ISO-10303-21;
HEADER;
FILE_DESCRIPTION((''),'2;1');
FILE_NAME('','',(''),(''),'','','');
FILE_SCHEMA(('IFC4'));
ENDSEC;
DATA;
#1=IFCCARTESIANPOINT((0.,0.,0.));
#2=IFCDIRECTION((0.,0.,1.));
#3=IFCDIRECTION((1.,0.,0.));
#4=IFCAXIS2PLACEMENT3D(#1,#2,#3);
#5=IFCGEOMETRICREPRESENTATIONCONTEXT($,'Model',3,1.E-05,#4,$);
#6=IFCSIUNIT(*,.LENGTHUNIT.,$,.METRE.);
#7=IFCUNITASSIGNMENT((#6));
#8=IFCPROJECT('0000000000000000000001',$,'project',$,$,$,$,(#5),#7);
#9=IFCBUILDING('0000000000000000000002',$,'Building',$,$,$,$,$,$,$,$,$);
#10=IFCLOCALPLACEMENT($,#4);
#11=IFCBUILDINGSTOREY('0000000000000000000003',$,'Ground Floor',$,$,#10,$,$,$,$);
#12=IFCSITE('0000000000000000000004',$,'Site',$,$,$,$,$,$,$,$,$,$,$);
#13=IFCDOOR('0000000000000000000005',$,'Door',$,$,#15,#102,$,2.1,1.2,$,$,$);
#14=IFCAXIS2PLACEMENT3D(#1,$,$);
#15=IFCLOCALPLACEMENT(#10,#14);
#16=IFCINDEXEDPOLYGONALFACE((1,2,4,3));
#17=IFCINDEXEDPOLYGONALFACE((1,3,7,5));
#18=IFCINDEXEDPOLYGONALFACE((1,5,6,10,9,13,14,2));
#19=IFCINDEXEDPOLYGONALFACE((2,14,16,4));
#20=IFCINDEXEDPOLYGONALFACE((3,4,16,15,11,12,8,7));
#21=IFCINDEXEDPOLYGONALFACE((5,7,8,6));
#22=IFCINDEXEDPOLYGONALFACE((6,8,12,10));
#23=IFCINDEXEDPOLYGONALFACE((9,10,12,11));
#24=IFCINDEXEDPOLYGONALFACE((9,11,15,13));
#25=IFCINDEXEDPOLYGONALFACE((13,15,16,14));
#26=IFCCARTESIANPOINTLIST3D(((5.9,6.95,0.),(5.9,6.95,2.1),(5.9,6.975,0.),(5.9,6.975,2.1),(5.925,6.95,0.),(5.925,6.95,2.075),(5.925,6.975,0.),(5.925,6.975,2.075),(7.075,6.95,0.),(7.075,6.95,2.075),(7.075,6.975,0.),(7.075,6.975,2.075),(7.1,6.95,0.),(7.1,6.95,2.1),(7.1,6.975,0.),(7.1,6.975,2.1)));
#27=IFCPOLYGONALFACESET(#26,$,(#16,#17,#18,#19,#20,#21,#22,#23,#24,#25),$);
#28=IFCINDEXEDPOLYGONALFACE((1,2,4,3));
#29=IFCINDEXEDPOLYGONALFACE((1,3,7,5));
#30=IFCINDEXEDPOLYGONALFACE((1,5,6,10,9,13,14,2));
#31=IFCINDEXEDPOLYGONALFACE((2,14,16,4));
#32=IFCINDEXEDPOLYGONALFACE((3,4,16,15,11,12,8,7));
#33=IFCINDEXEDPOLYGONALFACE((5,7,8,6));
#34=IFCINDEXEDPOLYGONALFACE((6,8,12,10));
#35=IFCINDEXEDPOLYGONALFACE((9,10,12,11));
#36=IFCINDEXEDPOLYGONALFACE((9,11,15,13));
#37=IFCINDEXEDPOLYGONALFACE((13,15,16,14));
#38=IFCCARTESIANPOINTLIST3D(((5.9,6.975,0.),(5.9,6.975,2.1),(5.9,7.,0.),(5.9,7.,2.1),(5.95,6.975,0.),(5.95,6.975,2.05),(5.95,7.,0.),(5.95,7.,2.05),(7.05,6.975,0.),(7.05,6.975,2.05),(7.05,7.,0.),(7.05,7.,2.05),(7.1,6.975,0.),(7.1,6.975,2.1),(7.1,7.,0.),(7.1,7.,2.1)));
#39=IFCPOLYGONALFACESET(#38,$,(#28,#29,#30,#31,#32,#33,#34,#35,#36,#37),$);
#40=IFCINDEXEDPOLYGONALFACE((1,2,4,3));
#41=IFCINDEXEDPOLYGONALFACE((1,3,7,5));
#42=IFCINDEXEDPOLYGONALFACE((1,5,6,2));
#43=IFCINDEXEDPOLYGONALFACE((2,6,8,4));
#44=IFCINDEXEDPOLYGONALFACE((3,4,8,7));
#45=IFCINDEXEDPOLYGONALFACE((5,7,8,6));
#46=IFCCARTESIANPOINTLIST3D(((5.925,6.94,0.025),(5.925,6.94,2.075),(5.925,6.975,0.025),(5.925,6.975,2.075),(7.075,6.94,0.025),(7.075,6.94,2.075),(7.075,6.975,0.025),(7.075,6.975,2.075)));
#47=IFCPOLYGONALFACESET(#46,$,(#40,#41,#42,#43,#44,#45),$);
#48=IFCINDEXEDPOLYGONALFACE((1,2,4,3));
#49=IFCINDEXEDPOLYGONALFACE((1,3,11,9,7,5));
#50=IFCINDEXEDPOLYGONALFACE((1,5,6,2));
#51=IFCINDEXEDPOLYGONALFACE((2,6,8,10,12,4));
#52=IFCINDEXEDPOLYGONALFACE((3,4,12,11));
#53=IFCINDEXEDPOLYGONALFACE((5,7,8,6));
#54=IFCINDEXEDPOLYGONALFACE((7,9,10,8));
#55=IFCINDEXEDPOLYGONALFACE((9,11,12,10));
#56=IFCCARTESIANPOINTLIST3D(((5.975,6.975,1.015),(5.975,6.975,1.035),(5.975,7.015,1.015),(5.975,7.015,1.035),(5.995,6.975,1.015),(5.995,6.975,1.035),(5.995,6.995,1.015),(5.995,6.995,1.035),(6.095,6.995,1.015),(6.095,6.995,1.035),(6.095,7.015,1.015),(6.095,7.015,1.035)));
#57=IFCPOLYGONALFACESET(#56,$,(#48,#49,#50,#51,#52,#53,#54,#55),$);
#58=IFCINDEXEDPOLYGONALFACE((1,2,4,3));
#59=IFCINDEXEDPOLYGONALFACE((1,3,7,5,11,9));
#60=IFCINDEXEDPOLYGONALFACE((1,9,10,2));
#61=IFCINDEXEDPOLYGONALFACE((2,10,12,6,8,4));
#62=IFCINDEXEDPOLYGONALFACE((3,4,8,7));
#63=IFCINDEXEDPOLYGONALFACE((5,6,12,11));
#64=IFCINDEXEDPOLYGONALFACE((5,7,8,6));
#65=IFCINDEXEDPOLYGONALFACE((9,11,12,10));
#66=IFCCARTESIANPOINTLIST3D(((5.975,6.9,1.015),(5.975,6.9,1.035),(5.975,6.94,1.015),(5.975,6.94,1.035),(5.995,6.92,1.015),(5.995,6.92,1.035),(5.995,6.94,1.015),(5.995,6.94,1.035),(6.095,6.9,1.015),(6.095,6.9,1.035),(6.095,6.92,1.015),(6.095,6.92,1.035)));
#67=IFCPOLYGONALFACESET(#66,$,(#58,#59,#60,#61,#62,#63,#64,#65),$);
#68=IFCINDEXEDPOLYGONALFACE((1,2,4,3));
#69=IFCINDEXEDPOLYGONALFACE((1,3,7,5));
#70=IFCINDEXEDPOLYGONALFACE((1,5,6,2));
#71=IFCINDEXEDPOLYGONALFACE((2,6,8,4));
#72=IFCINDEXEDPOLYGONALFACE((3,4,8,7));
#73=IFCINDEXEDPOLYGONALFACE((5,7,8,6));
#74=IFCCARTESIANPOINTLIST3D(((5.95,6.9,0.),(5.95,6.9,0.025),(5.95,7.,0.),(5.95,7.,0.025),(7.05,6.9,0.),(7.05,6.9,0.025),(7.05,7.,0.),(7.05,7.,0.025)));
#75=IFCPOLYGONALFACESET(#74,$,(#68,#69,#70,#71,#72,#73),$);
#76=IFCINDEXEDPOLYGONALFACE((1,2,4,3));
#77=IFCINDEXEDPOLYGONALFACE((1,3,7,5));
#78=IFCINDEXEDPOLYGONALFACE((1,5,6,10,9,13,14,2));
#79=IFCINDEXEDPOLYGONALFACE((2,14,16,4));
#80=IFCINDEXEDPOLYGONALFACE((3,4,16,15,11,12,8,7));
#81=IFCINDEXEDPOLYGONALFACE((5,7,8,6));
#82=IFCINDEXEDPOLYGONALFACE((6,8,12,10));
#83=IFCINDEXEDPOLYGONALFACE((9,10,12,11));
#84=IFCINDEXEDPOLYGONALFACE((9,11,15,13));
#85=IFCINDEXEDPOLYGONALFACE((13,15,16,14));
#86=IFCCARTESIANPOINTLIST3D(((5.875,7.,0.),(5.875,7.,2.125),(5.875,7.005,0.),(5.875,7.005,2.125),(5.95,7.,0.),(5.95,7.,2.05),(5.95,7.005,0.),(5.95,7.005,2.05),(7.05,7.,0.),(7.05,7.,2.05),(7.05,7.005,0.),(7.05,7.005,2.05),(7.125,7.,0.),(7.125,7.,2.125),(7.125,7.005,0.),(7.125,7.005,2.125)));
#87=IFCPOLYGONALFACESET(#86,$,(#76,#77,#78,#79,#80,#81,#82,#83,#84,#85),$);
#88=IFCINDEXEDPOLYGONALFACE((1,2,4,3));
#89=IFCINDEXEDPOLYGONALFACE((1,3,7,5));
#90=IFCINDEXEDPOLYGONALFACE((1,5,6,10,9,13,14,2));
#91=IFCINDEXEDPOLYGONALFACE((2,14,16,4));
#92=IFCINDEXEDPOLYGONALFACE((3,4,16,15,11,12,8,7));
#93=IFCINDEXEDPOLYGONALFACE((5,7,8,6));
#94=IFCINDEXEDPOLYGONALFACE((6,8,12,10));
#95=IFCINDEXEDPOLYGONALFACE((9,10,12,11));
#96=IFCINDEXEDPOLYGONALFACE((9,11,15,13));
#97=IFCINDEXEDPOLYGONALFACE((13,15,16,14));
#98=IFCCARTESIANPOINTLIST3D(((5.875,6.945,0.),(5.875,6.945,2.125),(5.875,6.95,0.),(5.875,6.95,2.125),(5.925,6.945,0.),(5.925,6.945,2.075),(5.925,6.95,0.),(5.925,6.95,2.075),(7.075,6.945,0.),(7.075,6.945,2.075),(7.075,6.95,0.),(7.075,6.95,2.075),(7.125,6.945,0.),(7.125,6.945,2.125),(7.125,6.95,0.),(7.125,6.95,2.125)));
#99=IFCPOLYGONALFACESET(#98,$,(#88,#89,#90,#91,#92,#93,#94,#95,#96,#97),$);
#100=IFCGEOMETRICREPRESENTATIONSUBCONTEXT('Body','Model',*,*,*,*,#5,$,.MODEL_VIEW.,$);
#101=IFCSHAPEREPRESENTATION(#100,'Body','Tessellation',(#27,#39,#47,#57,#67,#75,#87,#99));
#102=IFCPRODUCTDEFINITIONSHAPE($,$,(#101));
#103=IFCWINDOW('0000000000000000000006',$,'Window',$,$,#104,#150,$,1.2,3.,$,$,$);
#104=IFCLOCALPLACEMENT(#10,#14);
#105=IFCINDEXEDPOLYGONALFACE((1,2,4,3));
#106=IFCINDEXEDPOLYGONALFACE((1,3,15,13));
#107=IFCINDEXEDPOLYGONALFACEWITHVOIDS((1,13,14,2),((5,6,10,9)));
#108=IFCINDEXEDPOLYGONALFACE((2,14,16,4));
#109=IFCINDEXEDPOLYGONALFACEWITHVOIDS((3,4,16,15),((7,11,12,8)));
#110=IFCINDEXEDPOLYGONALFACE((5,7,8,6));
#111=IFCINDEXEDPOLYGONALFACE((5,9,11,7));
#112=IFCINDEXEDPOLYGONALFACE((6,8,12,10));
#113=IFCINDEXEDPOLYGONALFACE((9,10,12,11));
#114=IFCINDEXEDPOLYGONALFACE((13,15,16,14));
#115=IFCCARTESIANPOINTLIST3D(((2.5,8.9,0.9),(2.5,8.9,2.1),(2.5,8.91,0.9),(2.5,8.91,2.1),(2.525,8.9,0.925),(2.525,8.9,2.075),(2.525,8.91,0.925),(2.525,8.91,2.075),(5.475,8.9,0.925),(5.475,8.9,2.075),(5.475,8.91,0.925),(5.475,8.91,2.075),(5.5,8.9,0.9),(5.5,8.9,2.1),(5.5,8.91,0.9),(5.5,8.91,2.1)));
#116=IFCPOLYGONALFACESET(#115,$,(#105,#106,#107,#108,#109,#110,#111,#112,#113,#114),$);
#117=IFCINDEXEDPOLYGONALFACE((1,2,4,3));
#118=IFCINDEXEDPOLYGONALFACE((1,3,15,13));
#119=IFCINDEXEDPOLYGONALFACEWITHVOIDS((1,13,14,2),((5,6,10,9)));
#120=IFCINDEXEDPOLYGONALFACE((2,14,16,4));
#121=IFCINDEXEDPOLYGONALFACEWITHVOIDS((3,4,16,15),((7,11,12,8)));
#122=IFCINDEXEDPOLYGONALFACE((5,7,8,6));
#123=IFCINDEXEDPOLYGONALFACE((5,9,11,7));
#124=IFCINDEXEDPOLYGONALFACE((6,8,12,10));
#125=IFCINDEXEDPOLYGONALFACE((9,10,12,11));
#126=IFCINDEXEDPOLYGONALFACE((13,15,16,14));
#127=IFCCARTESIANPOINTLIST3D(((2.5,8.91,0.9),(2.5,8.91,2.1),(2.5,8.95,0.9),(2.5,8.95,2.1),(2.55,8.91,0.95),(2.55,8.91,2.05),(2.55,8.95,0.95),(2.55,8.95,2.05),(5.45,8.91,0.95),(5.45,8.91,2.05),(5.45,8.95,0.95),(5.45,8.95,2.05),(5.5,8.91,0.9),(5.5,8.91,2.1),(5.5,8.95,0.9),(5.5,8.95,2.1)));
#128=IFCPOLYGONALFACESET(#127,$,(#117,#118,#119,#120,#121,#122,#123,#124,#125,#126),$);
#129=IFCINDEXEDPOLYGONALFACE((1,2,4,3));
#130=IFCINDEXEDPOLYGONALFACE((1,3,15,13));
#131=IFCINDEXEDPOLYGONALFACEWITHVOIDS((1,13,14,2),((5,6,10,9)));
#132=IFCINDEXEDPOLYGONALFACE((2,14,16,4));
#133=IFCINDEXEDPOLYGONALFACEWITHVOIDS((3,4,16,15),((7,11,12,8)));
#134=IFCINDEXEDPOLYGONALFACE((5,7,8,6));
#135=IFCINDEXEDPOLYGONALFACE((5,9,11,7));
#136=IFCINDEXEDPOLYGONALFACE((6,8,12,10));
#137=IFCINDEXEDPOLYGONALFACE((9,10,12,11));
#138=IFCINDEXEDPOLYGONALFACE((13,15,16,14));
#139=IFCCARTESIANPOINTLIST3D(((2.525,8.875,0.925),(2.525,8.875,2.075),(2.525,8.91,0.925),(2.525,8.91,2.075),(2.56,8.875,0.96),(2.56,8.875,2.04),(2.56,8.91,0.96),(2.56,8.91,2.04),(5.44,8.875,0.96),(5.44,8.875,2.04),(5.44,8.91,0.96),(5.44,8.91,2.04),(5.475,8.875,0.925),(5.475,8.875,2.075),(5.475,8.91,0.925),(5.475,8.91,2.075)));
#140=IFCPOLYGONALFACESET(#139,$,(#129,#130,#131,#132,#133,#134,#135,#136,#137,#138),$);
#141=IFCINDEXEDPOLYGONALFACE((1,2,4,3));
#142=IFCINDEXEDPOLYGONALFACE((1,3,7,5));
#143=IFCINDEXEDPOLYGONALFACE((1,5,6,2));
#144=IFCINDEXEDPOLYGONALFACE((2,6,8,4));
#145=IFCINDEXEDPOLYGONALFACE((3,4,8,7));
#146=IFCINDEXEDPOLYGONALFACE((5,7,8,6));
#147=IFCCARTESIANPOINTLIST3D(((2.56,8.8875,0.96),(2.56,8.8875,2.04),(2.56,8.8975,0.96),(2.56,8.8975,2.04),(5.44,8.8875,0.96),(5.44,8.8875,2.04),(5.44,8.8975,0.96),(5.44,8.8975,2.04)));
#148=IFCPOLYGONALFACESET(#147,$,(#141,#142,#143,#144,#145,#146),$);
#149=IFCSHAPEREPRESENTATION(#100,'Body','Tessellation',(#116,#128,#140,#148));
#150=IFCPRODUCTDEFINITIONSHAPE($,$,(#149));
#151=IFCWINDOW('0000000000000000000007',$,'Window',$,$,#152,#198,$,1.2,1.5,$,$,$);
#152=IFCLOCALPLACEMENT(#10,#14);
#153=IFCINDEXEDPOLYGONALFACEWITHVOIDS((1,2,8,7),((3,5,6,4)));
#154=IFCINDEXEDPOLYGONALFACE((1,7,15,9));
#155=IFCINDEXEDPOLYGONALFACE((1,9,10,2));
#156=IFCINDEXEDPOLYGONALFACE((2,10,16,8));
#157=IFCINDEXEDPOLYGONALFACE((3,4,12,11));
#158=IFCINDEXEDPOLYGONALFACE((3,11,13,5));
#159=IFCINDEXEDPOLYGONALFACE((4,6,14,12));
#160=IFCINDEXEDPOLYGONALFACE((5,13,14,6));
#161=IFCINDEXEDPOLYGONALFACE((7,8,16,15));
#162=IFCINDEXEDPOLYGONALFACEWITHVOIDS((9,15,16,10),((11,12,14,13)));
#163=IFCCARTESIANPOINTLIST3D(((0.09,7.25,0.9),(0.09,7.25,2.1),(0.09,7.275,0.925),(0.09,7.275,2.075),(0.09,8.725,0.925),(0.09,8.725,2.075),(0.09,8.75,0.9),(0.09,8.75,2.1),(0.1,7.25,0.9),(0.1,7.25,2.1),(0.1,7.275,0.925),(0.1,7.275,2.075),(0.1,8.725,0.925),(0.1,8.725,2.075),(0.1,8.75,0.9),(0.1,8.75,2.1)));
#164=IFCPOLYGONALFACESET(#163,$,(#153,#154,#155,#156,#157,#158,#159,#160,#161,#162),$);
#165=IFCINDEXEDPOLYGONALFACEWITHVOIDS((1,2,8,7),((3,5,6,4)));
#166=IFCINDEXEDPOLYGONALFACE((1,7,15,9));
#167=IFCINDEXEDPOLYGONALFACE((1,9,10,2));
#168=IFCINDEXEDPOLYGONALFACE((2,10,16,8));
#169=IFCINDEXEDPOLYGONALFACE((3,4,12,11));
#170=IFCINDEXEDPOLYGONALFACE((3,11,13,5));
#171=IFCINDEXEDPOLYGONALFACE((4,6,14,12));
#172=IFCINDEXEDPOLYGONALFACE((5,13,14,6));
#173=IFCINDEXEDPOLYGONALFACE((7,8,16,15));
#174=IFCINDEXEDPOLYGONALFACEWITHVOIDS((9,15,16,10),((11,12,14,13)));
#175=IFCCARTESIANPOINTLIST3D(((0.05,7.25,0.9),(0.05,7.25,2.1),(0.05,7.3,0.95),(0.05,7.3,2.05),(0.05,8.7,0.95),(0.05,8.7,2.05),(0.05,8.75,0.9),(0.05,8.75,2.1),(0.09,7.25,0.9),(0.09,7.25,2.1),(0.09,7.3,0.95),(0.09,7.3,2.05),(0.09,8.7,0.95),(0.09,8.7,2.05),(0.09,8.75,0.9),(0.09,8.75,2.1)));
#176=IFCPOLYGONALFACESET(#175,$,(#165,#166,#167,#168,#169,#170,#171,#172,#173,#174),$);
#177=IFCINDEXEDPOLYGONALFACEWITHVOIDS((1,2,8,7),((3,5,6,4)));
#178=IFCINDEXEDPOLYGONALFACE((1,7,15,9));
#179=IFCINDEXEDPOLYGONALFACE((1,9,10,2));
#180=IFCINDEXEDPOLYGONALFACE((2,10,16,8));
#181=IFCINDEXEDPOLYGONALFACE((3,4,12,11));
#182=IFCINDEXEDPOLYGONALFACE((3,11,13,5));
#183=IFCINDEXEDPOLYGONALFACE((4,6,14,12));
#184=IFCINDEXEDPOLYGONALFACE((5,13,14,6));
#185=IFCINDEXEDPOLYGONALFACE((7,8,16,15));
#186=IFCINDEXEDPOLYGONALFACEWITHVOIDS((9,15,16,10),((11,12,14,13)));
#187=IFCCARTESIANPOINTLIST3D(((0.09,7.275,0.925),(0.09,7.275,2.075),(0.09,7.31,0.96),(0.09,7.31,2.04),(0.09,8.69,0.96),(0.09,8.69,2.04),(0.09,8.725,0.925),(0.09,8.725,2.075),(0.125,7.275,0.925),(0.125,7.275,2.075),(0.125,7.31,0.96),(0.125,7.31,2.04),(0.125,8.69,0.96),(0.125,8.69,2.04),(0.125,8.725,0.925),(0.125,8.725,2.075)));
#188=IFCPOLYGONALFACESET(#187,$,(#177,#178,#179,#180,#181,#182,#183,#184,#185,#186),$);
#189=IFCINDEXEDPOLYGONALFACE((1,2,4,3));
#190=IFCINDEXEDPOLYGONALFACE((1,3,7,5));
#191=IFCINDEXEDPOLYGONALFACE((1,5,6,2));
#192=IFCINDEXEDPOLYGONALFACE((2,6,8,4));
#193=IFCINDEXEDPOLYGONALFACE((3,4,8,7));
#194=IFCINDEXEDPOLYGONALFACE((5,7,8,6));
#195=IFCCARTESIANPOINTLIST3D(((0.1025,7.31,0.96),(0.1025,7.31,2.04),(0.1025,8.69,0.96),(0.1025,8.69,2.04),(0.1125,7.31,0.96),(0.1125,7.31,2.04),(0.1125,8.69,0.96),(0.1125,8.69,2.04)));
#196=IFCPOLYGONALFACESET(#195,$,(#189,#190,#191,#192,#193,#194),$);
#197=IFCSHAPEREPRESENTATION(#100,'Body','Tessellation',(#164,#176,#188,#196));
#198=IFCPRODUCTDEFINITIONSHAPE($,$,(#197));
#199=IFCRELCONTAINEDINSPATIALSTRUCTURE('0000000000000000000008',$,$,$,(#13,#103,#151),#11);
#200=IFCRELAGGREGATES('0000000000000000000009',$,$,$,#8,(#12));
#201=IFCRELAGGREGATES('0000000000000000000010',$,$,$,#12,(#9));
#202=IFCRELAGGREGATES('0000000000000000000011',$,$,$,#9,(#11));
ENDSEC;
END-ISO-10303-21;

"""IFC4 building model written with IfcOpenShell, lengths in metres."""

from ifc_helpers import new_model, si_unit, frame, origin_with_axes, place, context, subcontext, project, spatial, line, indexed_curve, outline, extrude, element, save


model = new_model("IFC4")

# Units and contexts
model_context = context("Model", 3, precision=1e-05, world=origin_with_axes())
body_context = subcontext(model_context, "Body", "Model", "MODEL_VIEW")
ifc_project = project(units=[si_unit("LENGTHUNIT", "METRE")], contexts=[model_context])

# Site, building, storey
site = spatial("IfcSite", under=ifc_project, Name="Site")
building = spatial("IfcBuilding", under=site, Name="Building")
storey_placement = place(None, origin_with_axes())
storey = spatial("IfcBuildingStorey", under=building, at=storey_placement, Name="Ground Floor")

# Door
door_1_placement = place(storey_placement, frame((7.1, 7.0, 0.0), z_axis=(0.0, 0.0, 1.0), x_axis=(-1.0, 0.0, 0.0)))
element("IfcDoor", 1, at=door_1_placement, inside=storey, Name="Door", OverallHeight=2.1, OverallWidth=1.2, context=body_context, shape_type="SweptSolid", body=[
    extrude(outline(indexed_curve([(0.0, 0.0), (0.0, 2.1), (1.2, 2.1), (1.2, 0.0), (1.175, 0.0), (1.175, 2.075), (0.025, 2.075), (0.025, 0.0)], segments=[line(1, 2, 3, 4, 5, 6, 7, 8, 1)])), frame((0.0, 0.025, 0.0), z_axis=(0.0, -1.0, 0.0), x_axis=(1.0, 0.0, 0.0)), (0.0, 0.0, -1.0), 0.025),
    extrude(outline(indexed_curve([(0.0, 0.0), (0.0, 2.1), (1.2, 2.1), (1.2, 0.0), (1.15, 0.0), (1.15, 2.05), (0.05, 2.05), (0.05, 0.0)], segments=[line(1, 2, 3, 4, 5, 6, 7, 8, 1)])), frame((0.0, 0.0, 0.0), z_axis=(0.0, -1.0, 0.0), x_axis=(1.0, 0.0, 0.0)), (0.0, 0.0, -1.0), 0.025),
    extrude(outline(indexed_curve([(0.0, 0.0), (1.15, 0.0), (1.15, 0.035), (0.0, 0.035)], segments=[line(1, 2, 3, 4, 1)])), frame((0.025, 0.025, 0.025), z_axis=(0.0, 0.0, 1.0), x_axis=(1.0, 0.0, 0.0)), (0.0, 0.0, 1.0), 2.05),
    extrude(outline(indexed_curve([(0.0, 0.0), (0.0, -0.04), (-0.12, -0.04), (-0.12, -0.02), (-0.02, -0.02), (-0.02, 0.0)], segments=[line(1, 2, 3, 4, 5, 6, 1)])), frame((1.125, 0.025, 1.015), z_axis=(0.0, 0.0, 1.0), x_axis=(1.0, 0.0, 0.0)), (0.0, 0.0, 1.0), 0.02),
    extrude(outline(indexed_curve([(0.0, 0.0), (0.0, 0.04), (-0.12, 0.04), (-0.12, 0.02), (-0.02, 0.02), (-0.02, 0.0)], segments=[line(1, 2, 3, 4, 5, 6, 1)])), frame((1.125, 0.06, 1.015), z_axis=(0.0, 0.0, 1.0), x_axis=(1.0, 0.0, 0.0)), (0.0, 0.0, 1.0), 0.02),
    extrude(outline(indexed_curve([(0.0, 0.0), (1.1, 0.0), (1.1, 0.1), (0.0, 0.1)], segments=[line(1, 2, 3, 4, 1)])), frame((0.05, 0.0, 0.0), z_axis=(0.0, 0.0, 1.0), x_axis=(1.0, 0.0, 0.0)), (0.0, 0.0, 1.0), 0.025),
    extrude(outline(indexed_curve([(0.0, 0.0), (0.0, 2.125), (1.25, 2.125), (1.25, 0.0), (1.175, 0.0), (1.175, 2.05), (0.075, 2.05), (0.075, 0.0)], segments=[line(1, 2, 3, 4, 5, 6, 7, 8, 1)])), frame((-0.025, -0.005, 0.0), z_axis=(0.0, -1.0, 0.0), x_axis=(1.0, 0.0, 0.0)), (0.0, 0.0, -1.0), 0.005),
    extrude(outline(indexed_curve([(0.0, 0.0), (0.0, 2.125), (1.25, 2.125), (1.25, 0.0), (1.2, 0.0), (1.2, 2.075), (0.05, 2.075), (0.05, 0.0)], segments=[line(1, 2, 3, 4, 5, 6, 7, 8, 1)])), frame((-0.025, 0.05, 0.0), z_axis=(0.0, -1.0, 0.0), x_axis=(1.0, 0.0, 0.0)), (0.0, 0.0, -1.0), 0.005),
])

# Windows
window_1_placement = place(storey_placement, frame((5.5, 9.0, 0.9), z_axis=(0.0, 0.0, 1.0), x_axis=(-1.0, 0.0, 0.0)))
element("IfcWindow", 2, at=window_1_placement, inside=storey, Name="Window", OverallHeight=1.2, OverallWidth=3.0, context=body_context, shape_type="SweptSolid", body=[
    extrude(outline(indexed_curve([(0.0, 0.0), (3.0, 0.0), (3.0, 1.2), (0.0, 1.2)], segments=[line(1, 2, 3, 4, 1)]), holes=[indexed_curve([(0.025, 0.025), (2.975, 0.025), (2.975, 1.175), (0.025, 1.175)], segments=[line(1, 2, 3, 4, 1)])]), frame((0.0, 0.09, 0.0), z_axis=(0.0, -1.0, 0.0), x_axis=(1.0, 0.0, 0.0)), (0.0, 0.0, -1.0), 0.01),
    extrude(outline(indexed_curve([(0.0, 0.0), (3.0, 0.0), (3.0, 1.2), (0.0, 1.2)], segments=[line(1, 2, 3, 4, 1)]), holes=[indexed_curve([(0.05, 0.05), (2.95, 0.05), (2.95, 1.15), (0.05, 1.15)], segments=[line(1, 2, 3, 4, 1)])]), frame((0.0, 0.05, 0.0), z_axis=(0.0, -1.0, 0.0), x_axis=(1.0, 0.0, 0.0)), (0.0, 0.0, -1.0), 0.04),
    extrude(outline(indexed_curve([(0.0, 0.0), (2.95, 0.0), (2.95, 1.15), (0.0, 1.15)], segments=[line(1, 2, 3, 4, 1)]), holes=[indexed_curve([(0.035, 0.035), (2.915, 0.035), (2.915, 1.115), (0.035, 1.115)], segments=[line(1, 2, 3, 4, 1)])]), frame((0.025, 0.09, 0.025), z_axis=(0.0, -1.0, 0.0), x_axis=(1.0, 0.0, 0.0)), (0.0, 0.0, -1.0), 0.035),
    extrude(outline(indexed_curve([(0.035, 0.035), (2.915, 0.035), (2.915, 1.115), (0.035, 1.115)], segments=[line(1, 2, 3, 4, 1)])), frame((0.025, 0.1025, 0.025), z_axis=(0.0, -1.0, 0.0), x_axis=(1.0, 0.0, 0.0)), (0.0, 0.0, -1.0), 0.01),
])
for number, where, z_axis, x_axis, name in (
    (3, (0.0, 8.75, 0.9), (0.0, 0.0, 1.0), (0.0, -1.0, 0.0), "Window"),
):
    element("IfcWindow", number, at=place(storey_placement, frame(where, z_axis=z_axis, x_axis=x_axis)), inside=storey, Name=name, OverallHeight=1.2, OverallWidth=1.5, context=body_context, shape_type="SweptSolid", body=[
        extrude(outline(indexed_curve([(0.0, 0.0), (1.5, 0.0), (1.5, 1.2), (0.0, 1.2)], segments=[line(1, 2, 3, 4, 1)]), holes=[indexed_curve([(0.025, 0.025), (1.475, 0.025), (1.475, 1.175), (0.025, 1.175)], segments=[line(1, 2, 3, 4, 1)])]), frame((0.0, 0.09, 0.0), z_axis=(0.0, -1.0, 0.0), x_axis=(1.0, 0.0, 0.0)), (0.0, 0.0, -1.0), 0.01),
        extrude(outline(indexed_curve([(0.0, 0.0), (1.5, 0.0), (1.5, 1.2), (0.0, 1.2)], segments=[line(1, 2, 3, 4, 1)]), holes=[indexed_curve([(0.05, 0.05), (1.45, 0.05), (1.45, 1.15), (0.05, 1.15)], segments=[line(1, 2, 3, 4, 1)])]), frame((0.0, 0.05, 0.0), z_axis=(0.0, -1.0, 0.0), x_axis=(1.0, 0.0, 0.0)), (0.0, 0.0, -1.0), 0.04),
        extrude(outline(indexed_curve([(0.0, 0.0), (1.45, 0.0), (1.45, 1.15), (0.0, 1.15)], segments=[line(1, 2, 3, 4, 1)]), holes=[indexed_curve([(0.035, 0.035), (1.415, 0.035), (1.415, 1.115), (0.035, 1.115)], segments=[line(1, 2, 3, 4, 1)])]), frame((0.025, 0.09, 0.025), z_axis=(0.0, -1.0, 0.0), x_axis=(1.0, 0.0, 0.0)), (0.0, 0.0, -1.0), 0.035),
        extrude(outline(indexed_curve([(0.035, 0.035), (1.415, 0.035), (1.415, 1.115), (0.035, 1.115)], segments=[line(1, 2, 3, 4, 1)])), frame((0.025, 0.1025, 0.025), z_axis=(0.0, -1.0, 0.0), x_axis=(1.0, 0.0, 0.0)), (0.0, 0.0, -1.0), 0.01),
    ])

save(model, "model.ifc")
